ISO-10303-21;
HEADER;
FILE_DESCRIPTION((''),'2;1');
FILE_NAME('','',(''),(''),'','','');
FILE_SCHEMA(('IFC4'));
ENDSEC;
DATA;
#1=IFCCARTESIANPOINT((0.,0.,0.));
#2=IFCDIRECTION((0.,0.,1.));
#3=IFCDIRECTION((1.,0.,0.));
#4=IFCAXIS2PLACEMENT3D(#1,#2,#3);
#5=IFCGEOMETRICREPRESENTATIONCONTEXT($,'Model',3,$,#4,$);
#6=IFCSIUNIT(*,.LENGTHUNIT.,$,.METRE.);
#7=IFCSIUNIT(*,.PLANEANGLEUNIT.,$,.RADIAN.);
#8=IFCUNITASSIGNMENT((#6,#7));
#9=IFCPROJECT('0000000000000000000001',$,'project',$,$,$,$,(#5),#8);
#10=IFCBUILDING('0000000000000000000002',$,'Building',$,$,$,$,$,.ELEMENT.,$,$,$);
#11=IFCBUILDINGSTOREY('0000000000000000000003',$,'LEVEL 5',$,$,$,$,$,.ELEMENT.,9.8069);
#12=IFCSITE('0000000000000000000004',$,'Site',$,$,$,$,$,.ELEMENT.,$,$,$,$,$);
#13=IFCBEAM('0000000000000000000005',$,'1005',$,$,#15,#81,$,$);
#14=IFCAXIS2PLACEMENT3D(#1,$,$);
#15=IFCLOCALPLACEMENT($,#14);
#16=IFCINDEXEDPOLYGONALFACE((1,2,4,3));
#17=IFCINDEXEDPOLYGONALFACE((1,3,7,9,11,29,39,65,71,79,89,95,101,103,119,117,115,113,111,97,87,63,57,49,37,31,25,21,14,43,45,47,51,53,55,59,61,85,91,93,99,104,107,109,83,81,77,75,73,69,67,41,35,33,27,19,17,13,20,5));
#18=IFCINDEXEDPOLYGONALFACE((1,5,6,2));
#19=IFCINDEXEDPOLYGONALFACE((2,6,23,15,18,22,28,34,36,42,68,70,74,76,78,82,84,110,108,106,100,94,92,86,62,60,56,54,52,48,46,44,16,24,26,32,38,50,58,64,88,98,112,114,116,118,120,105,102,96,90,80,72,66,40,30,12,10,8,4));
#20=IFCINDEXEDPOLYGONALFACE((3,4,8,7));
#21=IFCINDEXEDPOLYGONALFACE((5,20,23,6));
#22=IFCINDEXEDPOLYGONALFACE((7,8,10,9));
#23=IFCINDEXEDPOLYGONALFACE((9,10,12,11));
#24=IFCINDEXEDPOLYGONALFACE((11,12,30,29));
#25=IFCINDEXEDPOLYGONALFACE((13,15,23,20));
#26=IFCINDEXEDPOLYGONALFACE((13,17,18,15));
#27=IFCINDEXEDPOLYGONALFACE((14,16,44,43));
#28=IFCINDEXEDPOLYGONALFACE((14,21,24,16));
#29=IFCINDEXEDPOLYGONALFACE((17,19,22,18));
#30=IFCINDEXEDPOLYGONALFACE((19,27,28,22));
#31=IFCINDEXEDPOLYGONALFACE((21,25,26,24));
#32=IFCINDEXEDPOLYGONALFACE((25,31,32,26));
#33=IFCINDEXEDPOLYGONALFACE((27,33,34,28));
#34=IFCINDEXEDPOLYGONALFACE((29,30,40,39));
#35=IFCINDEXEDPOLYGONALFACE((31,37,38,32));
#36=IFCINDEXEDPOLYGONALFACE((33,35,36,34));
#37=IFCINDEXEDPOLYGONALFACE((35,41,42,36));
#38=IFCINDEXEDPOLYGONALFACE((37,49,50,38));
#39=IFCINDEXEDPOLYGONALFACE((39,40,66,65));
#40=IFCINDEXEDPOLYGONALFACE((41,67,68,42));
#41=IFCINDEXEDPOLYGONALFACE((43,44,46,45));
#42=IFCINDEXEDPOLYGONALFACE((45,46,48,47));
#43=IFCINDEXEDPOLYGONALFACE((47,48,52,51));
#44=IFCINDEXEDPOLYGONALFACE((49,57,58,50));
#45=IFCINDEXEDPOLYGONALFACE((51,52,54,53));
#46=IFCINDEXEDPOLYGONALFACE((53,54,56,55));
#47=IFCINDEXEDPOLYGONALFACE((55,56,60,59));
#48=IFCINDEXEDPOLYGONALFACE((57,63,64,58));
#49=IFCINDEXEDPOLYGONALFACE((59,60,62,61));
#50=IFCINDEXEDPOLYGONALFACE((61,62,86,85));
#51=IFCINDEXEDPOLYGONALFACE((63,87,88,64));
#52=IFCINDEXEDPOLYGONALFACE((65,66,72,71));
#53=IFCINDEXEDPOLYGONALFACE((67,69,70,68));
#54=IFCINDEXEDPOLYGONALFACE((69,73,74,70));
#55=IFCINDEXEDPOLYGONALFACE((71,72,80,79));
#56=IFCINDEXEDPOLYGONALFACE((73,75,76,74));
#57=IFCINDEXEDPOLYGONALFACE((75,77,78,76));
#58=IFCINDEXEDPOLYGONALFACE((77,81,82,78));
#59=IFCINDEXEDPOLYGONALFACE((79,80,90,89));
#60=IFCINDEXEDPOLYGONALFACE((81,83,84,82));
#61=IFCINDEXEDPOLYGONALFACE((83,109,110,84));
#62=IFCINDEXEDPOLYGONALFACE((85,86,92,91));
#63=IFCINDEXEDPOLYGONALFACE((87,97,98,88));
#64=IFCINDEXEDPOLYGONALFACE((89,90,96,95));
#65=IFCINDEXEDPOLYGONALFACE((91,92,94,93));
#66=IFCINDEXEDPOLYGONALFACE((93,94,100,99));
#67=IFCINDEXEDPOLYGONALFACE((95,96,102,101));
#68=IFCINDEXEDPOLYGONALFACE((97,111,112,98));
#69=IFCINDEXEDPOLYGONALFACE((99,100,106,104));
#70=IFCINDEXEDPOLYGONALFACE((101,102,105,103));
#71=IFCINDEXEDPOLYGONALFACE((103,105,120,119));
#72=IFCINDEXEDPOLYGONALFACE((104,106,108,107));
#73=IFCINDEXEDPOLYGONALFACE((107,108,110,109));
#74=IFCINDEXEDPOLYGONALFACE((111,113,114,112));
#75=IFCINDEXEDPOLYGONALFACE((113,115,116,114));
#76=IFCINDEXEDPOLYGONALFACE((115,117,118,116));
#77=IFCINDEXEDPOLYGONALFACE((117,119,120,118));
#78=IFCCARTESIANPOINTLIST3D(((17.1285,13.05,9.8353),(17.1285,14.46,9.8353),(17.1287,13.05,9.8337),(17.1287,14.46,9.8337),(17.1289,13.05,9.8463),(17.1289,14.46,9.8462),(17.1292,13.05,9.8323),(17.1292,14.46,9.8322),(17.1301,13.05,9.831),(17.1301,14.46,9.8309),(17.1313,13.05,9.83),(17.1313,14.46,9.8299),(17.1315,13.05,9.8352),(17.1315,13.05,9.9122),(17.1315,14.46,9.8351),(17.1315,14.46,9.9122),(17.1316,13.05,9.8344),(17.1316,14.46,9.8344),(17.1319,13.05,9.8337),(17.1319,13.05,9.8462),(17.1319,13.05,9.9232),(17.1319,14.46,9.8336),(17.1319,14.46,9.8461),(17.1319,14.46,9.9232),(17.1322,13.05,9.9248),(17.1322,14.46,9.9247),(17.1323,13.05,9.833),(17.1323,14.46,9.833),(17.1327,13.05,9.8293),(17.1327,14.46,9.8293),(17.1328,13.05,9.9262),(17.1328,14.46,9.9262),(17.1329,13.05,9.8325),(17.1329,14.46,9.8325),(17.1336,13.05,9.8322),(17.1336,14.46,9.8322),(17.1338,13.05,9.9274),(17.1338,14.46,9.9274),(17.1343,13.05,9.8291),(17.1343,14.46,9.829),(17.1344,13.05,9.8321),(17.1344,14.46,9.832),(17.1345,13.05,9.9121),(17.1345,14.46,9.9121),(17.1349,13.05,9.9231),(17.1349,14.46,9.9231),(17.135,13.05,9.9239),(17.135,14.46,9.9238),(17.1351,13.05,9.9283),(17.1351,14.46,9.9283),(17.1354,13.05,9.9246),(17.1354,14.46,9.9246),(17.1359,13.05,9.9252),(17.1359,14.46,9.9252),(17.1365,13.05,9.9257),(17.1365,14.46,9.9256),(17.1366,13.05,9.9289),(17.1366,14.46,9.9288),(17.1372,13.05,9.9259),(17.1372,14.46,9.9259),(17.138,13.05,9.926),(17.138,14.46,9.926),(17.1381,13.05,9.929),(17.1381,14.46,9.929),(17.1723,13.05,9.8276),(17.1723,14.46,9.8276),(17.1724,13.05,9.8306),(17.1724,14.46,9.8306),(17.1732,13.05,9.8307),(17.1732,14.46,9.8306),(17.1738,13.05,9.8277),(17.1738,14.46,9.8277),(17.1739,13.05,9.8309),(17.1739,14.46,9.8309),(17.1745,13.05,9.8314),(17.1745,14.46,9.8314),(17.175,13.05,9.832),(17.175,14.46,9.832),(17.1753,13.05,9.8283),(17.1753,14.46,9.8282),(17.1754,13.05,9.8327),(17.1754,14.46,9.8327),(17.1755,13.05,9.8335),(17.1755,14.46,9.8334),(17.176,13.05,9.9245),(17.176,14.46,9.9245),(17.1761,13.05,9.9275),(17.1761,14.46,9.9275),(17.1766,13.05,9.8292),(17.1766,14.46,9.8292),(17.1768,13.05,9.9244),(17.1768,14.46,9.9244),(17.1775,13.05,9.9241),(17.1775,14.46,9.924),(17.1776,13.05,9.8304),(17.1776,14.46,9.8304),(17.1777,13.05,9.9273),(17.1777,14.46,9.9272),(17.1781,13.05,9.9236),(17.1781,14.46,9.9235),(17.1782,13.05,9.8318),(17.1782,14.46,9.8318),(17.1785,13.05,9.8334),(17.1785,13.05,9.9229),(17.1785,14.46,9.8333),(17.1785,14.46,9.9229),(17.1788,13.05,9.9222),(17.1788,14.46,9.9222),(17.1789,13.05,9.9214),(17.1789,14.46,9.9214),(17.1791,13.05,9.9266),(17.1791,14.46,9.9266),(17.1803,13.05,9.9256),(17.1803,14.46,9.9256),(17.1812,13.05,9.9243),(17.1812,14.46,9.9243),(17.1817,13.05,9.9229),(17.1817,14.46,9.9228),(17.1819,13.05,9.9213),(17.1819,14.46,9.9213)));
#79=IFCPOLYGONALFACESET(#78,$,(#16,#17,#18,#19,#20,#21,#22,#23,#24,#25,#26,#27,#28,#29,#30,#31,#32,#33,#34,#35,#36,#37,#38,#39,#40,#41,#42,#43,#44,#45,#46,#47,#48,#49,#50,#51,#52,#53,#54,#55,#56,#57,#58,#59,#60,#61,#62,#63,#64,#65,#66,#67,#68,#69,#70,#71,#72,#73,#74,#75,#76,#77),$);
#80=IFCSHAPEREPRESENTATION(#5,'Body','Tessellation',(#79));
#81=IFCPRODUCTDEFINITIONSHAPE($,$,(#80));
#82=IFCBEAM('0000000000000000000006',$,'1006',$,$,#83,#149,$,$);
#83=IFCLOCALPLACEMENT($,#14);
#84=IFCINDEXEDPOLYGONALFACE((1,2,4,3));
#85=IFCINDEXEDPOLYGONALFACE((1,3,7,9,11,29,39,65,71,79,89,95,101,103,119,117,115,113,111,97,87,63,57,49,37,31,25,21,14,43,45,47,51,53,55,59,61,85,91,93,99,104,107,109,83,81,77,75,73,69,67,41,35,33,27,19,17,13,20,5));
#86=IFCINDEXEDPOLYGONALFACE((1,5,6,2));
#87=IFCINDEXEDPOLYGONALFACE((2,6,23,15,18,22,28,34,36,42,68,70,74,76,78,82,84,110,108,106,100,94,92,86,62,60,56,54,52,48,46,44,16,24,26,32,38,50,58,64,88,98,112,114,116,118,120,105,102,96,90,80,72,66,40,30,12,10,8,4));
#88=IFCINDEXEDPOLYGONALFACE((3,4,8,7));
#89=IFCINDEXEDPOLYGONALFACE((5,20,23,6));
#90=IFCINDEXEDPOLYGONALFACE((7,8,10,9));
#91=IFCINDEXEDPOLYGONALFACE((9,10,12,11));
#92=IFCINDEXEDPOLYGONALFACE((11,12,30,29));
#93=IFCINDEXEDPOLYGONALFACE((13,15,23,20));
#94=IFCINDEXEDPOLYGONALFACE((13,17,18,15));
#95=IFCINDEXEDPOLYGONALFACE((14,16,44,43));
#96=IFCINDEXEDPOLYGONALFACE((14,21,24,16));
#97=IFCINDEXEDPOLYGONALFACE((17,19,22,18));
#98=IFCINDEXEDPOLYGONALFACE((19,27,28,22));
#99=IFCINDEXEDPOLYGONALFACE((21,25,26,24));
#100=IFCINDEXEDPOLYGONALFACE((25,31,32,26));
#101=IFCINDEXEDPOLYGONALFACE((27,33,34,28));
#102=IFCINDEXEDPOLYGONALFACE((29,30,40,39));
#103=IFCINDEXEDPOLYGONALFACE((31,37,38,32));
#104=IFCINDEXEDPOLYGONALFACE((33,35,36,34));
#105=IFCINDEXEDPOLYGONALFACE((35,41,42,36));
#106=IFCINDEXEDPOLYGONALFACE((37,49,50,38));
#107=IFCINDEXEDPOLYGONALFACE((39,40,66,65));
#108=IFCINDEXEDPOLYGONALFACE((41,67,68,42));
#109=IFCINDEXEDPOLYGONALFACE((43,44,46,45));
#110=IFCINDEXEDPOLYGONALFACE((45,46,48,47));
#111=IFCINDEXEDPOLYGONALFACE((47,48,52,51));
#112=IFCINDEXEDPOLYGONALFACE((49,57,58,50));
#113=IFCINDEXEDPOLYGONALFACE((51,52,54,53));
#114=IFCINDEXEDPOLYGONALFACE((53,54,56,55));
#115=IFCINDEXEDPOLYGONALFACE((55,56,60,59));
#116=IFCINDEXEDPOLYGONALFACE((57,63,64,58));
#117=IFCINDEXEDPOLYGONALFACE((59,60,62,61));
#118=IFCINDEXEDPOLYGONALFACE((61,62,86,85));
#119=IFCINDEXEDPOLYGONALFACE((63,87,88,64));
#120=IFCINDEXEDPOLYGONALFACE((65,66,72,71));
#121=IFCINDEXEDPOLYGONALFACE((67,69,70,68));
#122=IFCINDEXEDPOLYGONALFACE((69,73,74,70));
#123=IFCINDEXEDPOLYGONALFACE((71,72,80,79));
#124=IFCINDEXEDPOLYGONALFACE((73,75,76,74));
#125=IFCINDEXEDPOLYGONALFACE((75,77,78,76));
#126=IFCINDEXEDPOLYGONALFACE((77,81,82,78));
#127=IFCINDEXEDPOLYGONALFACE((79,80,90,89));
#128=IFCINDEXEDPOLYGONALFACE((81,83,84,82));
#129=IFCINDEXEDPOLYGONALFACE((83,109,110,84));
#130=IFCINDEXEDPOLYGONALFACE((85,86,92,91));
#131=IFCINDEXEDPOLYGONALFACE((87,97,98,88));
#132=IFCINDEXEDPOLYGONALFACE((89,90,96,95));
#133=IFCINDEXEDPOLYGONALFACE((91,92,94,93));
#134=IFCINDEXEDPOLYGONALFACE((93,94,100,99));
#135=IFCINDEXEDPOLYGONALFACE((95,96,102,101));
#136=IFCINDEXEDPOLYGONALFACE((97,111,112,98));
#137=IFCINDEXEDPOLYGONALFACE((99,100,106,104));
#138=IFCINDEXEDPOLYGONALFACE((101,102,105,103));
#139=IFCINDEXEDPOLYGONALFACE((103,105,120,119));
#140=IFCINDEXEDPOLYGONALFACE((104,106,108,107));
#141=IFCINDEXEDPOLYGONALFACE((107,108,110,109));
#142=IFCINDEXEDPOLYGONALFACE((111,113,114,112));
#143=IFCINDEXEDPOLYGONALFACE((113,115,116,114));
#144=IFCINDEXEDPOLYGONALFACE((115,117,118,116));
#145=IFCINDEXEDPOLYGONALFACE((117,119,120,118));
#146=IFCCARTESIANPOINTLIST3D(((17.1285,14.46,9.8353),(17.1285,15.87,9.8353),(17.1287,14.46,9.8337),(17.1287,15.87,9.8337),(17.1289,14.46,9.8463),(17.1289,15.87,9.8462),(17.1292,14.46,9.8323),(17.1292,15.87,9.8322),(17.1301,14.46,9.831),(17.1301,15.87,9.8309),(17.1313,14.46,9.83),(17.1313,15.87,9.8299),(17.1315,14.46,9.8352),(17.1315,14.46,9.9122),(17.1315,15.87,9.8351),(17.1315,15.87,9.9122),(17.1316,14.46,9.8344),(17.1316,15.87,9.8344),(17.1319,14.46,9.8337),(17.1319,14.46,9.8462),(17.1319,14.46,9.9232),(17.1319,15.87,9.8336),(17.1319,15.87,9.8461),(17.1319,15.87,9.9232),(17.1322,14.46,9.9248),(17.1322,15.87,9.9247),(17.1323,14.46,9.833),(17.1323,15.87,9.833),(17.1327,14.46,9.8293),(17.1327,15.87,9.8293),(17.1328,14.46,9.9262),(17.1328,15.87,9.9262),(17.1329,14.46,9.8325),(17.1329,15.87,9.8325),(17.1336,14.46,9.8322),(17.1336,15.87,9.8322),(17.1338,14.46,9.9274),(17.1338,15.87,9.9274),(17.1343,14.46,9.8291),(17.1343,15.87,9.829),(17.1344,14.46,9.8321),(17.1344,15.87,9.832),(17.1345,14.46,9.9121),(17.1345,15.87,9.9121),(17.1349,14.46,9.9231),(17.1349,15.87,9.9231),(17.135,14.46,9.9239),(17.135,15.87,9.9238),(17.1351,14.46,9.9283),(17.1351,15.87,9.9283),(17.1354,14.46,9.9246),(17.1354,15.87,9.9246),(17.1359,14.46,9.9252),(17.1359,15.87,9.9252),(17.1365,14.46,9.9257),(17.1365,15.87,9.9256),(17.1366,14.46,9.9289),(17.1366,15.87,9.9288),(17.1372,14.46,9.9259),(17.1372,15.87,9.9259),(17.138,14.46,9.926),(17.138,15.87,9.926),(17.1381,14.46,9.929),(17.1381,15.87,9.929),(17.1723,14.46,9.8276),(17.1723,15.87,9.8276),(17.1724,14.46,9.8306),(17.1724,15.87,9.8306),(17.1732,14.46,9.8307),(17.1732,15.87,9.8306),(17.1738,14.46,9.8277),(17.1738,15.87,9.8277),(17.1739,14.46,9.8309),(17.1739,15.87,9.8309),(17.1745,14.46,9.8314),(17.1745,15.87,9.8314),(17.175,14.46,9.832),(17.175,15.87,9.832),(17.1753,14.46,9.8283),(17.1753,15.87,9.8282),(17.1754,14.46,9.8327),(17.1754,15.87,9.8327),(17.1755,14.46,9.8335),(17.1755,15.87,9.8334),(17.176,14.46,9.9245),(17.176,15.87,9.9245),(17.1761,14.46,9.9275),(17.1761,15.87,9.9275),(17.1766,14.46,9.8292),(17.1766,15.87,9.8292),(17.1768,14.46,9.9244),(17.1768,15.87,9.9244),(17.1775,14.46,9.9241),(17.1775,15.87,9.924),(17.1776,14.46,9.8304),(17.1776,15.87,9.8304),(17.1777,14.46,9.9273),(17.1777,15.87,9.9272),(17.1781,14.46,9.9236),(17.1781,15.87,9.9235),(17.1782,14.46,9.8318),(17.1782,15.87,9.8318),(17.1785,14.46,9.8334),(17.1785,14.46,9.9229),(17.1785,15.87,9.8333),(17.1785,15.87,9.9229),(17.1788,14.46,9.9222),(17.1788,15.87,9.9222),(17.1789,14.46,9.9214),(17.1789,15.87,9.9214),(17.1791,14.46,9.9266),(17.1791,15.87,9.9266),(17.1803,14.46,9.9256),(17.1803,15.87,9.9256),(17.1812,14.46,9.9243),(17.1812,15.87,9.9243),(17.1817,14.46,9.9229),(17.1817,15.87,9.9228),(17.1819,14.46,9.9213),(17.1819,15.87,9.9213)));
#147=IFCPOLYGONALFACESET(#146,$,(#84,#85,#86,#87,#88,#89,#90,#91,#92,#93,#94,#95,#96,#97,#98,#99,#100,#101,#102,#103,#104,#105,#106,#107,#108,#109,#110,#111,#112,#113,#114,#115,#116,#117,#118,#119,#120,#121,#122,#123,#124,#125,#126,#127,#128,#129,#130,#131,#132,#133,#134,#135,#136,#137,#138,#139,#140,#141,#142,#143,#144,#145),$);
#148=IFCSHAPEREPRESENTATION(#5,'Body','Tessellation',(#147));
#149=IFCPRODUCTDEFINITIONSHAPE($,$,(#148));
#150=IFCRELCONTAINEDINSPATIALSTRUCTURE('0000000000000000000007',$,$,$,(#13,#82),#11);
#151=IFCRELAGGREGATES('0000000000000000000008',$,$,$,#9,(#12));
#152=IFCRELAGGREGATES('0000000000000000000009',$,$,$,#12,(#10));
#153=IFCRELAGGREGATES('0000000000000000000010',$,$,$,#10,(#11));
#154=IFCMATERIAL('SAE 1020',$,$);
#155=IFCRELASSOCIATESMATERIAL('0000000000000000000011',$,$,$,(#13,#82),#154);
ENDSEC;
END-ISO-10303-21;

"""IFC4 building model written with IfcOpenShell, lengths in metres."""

from ifc_helpers import new_model, si_unit, frame, origin_with_axes, origin_2d_with_axis, place, context, project, spatial, c_section, extrude, material, material_profile, profile_set, profile_usage, element, save


model = new_model("IFC4")

# Units and contexts
model_context = context("Model", 3, world=origin_with_axes())
ifc_project = project(units=[si_unit("LENGTHUNIT", "METRE"), si_unit("PLANEANGLEUNIT", "RADIAN")], contexts=[model_context])

# Site, building, storey
site = spatial("IfcSite", under=ifc_project, Name="Site", CompositionType="ELEMENT")
building = spatial("IfcBuilding", under=site, Name="Building", CompositionType="ELEMENT")
storey = spatial("IfcBuildingStorey", under=building, Name="LEVEL 5", CompositionType="ELEMENT", Elevation=9.8069)

# Beams
ifc_material = material(Name="SAE 1020")
ifc_material_profile_1 = material_profile(ifc_material, c_section(Depth=0.1, Width=0.05, WallThickness=0.003, Girth=0.017, InternalFilletRadius=0.003, at=origin_2d_with_axis()))
ifc_profile_set_1 = profile_set([ifc_material_profile_1])
ifc_profile_usage_1 = profile_usage(ifc_profile_set_1, cardinal=10)
beam_1_placement = place(None, frame((17.1552, 13.05, 9.8783), z_axis=(0.0, 1.0, -0.00003), x_axis=(-0.999256, 0.000001, 0.038562)))
element("IfcBeam", 1, at=beam_1_placement, inside=storey, material=ifc_profile_usage_1, Name="1005", context=model_context, shape_type="SweptSolid", body=[
    extrude(c_section(Depth=0.1, Width=0.05, WallThickness=0.003, Girth=0.017, InternalFilletRadius=0.003, at=origin_2d_with_axis()), origin_with_axes(), (0.0, 0.0, 1.0), 1.41),
])
ifc_material_profile_2 = material_profile(ifc_material, c_section(Depth=0.1, Width=0.05, WallThickness=0.003, Girth=0.017, InternalFilletRadius=0.003, at=origin_2d_with_axis()))
ifc_profile_set_2 = profile_set([ifc_material_profile_2])
ifc_profile_usage_2 = profile_usage(ifc_profile_set_2, cardinal=10)
beam_2_placement = place(None, frame((17.1552, 14.46, 9.8783), z_axis=(0.0, 1.0, -0.00003), x_axis=(-0.999256, 0.000001, 0.038562)))
element("IfcBeam", 2, at=beam_2_placement, inside=storey, material=ifc_profile_usage_2, Name="1006", context=model_context, shape_type="SweptSolid", body=[
    extrude(c_section(Depth=0.1, Width=0.05, WallThickness=0.003, Girth=0.017, InternalFilletRadius=0.003, at=origin_2d_with_axis()), origin_with_axes(), (0.0, 0.0, 1.0), 1.41),
])

save(model, "model.ifc")
